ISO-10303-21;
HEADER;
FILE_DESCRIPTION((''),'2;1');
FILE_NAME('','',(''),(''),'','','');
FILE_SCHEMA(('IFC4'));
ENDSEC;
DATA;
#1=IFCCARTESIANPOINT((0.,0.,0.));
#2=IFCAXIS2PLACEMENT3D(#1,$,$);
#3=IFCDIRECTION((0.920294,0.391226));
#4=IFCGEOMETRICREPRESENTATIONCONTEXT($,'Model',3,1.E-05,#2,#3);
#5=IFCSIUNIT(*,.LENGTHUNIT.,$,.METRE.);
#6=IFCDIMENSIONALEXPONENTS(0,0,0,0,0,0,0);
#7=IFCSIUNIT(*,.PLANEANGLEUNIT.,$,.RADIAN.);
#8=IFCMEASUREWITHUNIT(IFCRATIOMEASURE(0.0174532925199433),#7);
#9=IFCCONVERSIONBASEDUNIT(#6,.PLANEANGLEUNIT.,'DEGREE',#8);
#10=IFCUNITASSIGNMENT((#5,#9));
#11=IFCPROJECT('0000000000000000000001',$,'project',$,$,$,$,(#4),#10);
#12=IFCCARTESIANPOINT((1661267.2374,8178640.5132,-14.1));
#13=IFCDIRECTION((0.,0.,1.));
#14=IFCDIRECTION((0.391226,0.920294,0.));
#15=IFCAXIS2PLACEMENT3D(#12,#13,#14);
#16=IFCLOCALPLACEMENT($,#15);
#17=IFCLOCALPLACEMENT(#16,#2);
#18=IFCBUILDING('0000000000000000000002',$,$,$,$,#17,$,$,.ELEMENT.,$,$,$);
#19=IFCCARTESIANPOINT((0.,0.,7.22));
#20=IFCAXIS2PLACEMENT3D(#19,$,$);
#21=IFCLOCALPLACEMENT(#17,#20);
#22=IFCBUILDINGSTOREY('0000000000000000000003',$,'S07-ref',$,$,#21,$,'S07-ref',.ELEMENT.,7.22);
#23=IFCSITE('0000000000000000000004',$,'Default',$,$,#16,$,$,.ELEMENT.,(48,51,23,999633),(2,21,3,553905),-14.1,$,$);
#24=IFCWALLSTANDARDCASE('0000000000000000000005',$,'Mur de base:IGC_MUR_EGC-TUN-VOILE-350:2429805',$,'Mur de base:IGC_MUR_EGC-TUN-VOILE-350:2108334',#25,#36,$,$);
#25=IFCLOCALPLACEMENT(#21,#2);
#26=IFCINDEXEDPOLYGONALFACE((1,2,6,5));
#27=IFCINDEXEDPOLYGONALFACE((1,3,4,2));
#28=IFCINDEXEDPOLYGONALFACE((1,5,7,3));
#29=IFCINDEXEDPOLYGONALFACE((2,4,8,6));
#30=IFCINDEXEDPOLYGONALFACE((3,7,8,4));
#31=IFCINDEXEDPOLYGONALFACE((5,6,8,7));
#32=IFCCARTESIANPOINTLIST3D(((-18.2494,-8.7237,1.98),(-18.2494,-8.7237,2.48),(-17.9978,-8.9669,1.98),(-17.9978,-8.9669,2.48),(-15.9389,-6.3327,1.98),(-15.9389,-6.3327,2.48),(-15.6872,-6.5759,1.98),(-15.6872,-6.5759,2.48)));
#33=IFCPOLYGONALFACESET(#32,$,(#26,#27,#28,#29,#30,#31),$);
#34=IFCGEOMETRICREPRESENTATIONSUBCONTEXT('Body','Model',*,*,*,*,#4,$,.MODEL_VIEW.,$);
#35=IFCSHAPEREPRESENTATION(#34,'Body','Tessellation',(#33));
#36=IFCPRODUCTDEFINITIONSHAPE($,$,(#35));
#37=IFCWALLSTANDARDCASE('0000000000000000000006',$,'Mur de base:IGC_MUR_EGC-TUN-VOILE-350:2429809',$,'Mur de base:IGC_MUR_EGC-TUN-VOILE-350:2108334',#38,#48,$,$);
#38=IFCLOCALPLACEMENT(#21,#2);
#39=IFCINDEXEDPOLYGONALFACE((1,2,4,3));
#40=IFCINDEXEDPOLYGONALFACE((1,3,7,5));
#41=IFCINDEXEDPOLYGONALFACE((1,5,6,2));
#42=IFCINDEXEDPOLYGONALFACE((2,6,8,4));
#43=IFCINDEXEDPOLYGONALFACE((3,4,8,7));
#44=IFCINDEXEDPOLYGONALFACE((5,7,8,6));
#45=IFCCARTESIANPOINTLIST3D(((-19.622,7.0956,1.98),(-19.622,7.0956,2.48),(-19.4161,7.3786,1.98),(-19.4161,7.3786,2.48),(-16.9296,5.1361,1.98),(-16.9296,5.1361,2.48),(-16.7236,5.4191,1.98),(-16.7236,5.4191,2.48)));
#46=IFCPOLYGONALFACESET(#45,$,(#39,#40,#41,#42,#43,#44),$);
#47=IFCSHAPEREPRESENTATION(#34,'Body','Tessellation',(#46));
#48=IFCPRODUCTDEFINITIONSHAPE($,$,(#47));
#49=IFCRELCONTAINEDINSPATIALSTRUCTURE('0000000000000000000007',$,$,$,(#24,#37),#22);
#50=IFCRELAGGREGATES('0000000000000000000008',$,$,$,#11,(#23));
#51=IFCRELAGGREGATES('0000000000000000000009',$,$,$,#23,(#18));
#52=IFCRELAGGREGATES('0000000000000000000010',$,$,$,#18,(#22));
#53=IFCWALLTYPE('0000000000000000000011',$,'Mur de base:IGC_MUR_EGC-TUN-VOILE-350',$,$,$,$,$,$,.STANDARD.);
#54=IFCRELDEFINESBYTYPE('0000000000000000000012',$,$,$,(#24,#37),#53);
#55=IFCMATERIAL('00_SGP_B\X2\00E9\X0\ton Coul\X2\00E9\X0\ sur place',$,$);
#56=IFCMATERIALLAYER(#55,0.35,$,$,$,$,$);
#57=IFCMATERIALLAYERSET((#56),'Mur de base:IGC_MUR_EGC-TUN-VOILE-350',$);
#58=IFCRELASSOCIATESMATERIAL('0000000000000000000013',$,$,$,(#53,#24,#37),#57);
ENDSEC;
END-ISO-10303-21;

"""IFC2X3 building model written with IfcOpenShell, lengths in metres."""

from ifc_helpers import new_model, entity, si_unit, converted_unit, direction, frame, frame_2d, origin, place, context, subcontext, project, spatial, rectangle, extrude, material, layer, layer_set, layer_usage, type_object, element, save


model = new_model("IFC2X3")

# Units and contexts
model_context = context("Model", 3, precision=1e-05, world=origin(), true_north=direction((0.920294, 0.391226)))
body_context = subcontext(model_context, "Body", "Model", "MODEL_VIEW")
ifc_project = project(units=[si_unit("LENGTHUNIT", "METRE"), converted_unit("PLANEANGLEUNIT", "DEGREE", entity("IfcRatioMeasure", 0.0174532925199433), si_unit("PLANEANGLEUNIT", "RADIAN"), dimensions=[0, 0, 0, 0, 0, 0, 0])], contexts=[model_context])

# Site, building, storey
site_placement = place(None, frame((1661267.2374, 8178640.5132, -14.1), z_axis=(0.0, 0.0, 1.0), x_axis=(0.391226, 0.920294, 0.0)))
site = spatial("IfcSite", under=ifc_project, at=site_placement, Name="Default", CompositionType="ELEMENT", RefLatitude=(48, 51, 23, 999633), RefLongitude=(2, 21, 3, 553905), RefElevation=-14.1)
building_placement = place(site_placement, origin())
building = spatial("IfcBuilding", under=site, at=building_placement, CompositionType="ELEMENT")
storey_placement = place(building_placement, frame((0.0, 0.0, 7.22)))
storey = spatial("IfcBuildingStorey", under=building, at=storey_placement, Name="S07-ref", LongName="S07-ref", CompositionType="ELEMENT", Elevation=7.22)

# Walls
ifc_material = material(Name="00_SGP_Béton Coulé sur place")
ifc_layer_1 = layer(ifc_material, 0.35)
ifc_layer_set_1 = layer_set([ifc_layer_1], Name="Mur de base:IGC_MUR_EGC-TUN-VOILE-350")
wall_type_1 = type_object("IfcWallType", Name="Mur de base:IGC_MUR_EGC-TUN-VOILE-350", PredefinedType="STANDARD", material=ifc_layer_set_1)
ifc_layer_usage_1 = layer_usage(ifc_layer_set_1, "AXIS2", "NEGATIVE", 0.175)
wall_1_placement = place(storey_placement, frame((-15.813, -6.4543, 1.98), z_axis=(0.0, 0.0, 1.0), x_axis=(-0.694907, -0.7191, 0.0)))
element("IfcWallStandardCase", 1, at=wall_1_placement, inside=storey, type_object=wall_type_1, material=ifc_layer_usage_1, Name="Mur de base:IGC_MUR_EGC-TUN-VOILE-350:2429805", ObjectType="Mur de base:IGC_MUR_EGC-TUN-VOILE-350:2108334", context=body_context, shape_type="SweptSolid", body=[
    extrude(rectangle(XDim=3.325, YDim=0.35, at=frame_2d((1.6625, 0.0), x_axis=(-1.0, 0.0))), origin(), (0.0, 0.0, 1.0), 0.5),
])
ifc_layer_usage_2 = layer_usage(ifc_layer_set_1, "AXIS2", "NEGATIVE", 0.175)
wall_2_placement = place(storey_placement, frame((-16.8266, 5.2776, 1.98), z_axis=(0.0, 0.0, 1.0), x_axis=(-0.808541, 0.58844, 0.0)))
element("IfcWallStandardCase", 2, at=wall_2_placement, inside=storey, type_object=wall_type_1, material=ifc_layer_usage_2, Name="Mur de base:IGC_MUR_EGC-TUN-VOILE-350:2429809", ObjectType="Mur de base:IGC_MUR_EGC-TUN-VOILE-350:2108334", context=body_context, shape_type="SweptSolid", body=[
    extrude(rectangle(XDim=3.33, YDim=0.35, at=frame_2d((1.665, 0.0), x_axis=(-1.0, 0.0))), origin(), (0.0, 0.0, 1.0), 0.5),
])

save(model, "model.ifc")
